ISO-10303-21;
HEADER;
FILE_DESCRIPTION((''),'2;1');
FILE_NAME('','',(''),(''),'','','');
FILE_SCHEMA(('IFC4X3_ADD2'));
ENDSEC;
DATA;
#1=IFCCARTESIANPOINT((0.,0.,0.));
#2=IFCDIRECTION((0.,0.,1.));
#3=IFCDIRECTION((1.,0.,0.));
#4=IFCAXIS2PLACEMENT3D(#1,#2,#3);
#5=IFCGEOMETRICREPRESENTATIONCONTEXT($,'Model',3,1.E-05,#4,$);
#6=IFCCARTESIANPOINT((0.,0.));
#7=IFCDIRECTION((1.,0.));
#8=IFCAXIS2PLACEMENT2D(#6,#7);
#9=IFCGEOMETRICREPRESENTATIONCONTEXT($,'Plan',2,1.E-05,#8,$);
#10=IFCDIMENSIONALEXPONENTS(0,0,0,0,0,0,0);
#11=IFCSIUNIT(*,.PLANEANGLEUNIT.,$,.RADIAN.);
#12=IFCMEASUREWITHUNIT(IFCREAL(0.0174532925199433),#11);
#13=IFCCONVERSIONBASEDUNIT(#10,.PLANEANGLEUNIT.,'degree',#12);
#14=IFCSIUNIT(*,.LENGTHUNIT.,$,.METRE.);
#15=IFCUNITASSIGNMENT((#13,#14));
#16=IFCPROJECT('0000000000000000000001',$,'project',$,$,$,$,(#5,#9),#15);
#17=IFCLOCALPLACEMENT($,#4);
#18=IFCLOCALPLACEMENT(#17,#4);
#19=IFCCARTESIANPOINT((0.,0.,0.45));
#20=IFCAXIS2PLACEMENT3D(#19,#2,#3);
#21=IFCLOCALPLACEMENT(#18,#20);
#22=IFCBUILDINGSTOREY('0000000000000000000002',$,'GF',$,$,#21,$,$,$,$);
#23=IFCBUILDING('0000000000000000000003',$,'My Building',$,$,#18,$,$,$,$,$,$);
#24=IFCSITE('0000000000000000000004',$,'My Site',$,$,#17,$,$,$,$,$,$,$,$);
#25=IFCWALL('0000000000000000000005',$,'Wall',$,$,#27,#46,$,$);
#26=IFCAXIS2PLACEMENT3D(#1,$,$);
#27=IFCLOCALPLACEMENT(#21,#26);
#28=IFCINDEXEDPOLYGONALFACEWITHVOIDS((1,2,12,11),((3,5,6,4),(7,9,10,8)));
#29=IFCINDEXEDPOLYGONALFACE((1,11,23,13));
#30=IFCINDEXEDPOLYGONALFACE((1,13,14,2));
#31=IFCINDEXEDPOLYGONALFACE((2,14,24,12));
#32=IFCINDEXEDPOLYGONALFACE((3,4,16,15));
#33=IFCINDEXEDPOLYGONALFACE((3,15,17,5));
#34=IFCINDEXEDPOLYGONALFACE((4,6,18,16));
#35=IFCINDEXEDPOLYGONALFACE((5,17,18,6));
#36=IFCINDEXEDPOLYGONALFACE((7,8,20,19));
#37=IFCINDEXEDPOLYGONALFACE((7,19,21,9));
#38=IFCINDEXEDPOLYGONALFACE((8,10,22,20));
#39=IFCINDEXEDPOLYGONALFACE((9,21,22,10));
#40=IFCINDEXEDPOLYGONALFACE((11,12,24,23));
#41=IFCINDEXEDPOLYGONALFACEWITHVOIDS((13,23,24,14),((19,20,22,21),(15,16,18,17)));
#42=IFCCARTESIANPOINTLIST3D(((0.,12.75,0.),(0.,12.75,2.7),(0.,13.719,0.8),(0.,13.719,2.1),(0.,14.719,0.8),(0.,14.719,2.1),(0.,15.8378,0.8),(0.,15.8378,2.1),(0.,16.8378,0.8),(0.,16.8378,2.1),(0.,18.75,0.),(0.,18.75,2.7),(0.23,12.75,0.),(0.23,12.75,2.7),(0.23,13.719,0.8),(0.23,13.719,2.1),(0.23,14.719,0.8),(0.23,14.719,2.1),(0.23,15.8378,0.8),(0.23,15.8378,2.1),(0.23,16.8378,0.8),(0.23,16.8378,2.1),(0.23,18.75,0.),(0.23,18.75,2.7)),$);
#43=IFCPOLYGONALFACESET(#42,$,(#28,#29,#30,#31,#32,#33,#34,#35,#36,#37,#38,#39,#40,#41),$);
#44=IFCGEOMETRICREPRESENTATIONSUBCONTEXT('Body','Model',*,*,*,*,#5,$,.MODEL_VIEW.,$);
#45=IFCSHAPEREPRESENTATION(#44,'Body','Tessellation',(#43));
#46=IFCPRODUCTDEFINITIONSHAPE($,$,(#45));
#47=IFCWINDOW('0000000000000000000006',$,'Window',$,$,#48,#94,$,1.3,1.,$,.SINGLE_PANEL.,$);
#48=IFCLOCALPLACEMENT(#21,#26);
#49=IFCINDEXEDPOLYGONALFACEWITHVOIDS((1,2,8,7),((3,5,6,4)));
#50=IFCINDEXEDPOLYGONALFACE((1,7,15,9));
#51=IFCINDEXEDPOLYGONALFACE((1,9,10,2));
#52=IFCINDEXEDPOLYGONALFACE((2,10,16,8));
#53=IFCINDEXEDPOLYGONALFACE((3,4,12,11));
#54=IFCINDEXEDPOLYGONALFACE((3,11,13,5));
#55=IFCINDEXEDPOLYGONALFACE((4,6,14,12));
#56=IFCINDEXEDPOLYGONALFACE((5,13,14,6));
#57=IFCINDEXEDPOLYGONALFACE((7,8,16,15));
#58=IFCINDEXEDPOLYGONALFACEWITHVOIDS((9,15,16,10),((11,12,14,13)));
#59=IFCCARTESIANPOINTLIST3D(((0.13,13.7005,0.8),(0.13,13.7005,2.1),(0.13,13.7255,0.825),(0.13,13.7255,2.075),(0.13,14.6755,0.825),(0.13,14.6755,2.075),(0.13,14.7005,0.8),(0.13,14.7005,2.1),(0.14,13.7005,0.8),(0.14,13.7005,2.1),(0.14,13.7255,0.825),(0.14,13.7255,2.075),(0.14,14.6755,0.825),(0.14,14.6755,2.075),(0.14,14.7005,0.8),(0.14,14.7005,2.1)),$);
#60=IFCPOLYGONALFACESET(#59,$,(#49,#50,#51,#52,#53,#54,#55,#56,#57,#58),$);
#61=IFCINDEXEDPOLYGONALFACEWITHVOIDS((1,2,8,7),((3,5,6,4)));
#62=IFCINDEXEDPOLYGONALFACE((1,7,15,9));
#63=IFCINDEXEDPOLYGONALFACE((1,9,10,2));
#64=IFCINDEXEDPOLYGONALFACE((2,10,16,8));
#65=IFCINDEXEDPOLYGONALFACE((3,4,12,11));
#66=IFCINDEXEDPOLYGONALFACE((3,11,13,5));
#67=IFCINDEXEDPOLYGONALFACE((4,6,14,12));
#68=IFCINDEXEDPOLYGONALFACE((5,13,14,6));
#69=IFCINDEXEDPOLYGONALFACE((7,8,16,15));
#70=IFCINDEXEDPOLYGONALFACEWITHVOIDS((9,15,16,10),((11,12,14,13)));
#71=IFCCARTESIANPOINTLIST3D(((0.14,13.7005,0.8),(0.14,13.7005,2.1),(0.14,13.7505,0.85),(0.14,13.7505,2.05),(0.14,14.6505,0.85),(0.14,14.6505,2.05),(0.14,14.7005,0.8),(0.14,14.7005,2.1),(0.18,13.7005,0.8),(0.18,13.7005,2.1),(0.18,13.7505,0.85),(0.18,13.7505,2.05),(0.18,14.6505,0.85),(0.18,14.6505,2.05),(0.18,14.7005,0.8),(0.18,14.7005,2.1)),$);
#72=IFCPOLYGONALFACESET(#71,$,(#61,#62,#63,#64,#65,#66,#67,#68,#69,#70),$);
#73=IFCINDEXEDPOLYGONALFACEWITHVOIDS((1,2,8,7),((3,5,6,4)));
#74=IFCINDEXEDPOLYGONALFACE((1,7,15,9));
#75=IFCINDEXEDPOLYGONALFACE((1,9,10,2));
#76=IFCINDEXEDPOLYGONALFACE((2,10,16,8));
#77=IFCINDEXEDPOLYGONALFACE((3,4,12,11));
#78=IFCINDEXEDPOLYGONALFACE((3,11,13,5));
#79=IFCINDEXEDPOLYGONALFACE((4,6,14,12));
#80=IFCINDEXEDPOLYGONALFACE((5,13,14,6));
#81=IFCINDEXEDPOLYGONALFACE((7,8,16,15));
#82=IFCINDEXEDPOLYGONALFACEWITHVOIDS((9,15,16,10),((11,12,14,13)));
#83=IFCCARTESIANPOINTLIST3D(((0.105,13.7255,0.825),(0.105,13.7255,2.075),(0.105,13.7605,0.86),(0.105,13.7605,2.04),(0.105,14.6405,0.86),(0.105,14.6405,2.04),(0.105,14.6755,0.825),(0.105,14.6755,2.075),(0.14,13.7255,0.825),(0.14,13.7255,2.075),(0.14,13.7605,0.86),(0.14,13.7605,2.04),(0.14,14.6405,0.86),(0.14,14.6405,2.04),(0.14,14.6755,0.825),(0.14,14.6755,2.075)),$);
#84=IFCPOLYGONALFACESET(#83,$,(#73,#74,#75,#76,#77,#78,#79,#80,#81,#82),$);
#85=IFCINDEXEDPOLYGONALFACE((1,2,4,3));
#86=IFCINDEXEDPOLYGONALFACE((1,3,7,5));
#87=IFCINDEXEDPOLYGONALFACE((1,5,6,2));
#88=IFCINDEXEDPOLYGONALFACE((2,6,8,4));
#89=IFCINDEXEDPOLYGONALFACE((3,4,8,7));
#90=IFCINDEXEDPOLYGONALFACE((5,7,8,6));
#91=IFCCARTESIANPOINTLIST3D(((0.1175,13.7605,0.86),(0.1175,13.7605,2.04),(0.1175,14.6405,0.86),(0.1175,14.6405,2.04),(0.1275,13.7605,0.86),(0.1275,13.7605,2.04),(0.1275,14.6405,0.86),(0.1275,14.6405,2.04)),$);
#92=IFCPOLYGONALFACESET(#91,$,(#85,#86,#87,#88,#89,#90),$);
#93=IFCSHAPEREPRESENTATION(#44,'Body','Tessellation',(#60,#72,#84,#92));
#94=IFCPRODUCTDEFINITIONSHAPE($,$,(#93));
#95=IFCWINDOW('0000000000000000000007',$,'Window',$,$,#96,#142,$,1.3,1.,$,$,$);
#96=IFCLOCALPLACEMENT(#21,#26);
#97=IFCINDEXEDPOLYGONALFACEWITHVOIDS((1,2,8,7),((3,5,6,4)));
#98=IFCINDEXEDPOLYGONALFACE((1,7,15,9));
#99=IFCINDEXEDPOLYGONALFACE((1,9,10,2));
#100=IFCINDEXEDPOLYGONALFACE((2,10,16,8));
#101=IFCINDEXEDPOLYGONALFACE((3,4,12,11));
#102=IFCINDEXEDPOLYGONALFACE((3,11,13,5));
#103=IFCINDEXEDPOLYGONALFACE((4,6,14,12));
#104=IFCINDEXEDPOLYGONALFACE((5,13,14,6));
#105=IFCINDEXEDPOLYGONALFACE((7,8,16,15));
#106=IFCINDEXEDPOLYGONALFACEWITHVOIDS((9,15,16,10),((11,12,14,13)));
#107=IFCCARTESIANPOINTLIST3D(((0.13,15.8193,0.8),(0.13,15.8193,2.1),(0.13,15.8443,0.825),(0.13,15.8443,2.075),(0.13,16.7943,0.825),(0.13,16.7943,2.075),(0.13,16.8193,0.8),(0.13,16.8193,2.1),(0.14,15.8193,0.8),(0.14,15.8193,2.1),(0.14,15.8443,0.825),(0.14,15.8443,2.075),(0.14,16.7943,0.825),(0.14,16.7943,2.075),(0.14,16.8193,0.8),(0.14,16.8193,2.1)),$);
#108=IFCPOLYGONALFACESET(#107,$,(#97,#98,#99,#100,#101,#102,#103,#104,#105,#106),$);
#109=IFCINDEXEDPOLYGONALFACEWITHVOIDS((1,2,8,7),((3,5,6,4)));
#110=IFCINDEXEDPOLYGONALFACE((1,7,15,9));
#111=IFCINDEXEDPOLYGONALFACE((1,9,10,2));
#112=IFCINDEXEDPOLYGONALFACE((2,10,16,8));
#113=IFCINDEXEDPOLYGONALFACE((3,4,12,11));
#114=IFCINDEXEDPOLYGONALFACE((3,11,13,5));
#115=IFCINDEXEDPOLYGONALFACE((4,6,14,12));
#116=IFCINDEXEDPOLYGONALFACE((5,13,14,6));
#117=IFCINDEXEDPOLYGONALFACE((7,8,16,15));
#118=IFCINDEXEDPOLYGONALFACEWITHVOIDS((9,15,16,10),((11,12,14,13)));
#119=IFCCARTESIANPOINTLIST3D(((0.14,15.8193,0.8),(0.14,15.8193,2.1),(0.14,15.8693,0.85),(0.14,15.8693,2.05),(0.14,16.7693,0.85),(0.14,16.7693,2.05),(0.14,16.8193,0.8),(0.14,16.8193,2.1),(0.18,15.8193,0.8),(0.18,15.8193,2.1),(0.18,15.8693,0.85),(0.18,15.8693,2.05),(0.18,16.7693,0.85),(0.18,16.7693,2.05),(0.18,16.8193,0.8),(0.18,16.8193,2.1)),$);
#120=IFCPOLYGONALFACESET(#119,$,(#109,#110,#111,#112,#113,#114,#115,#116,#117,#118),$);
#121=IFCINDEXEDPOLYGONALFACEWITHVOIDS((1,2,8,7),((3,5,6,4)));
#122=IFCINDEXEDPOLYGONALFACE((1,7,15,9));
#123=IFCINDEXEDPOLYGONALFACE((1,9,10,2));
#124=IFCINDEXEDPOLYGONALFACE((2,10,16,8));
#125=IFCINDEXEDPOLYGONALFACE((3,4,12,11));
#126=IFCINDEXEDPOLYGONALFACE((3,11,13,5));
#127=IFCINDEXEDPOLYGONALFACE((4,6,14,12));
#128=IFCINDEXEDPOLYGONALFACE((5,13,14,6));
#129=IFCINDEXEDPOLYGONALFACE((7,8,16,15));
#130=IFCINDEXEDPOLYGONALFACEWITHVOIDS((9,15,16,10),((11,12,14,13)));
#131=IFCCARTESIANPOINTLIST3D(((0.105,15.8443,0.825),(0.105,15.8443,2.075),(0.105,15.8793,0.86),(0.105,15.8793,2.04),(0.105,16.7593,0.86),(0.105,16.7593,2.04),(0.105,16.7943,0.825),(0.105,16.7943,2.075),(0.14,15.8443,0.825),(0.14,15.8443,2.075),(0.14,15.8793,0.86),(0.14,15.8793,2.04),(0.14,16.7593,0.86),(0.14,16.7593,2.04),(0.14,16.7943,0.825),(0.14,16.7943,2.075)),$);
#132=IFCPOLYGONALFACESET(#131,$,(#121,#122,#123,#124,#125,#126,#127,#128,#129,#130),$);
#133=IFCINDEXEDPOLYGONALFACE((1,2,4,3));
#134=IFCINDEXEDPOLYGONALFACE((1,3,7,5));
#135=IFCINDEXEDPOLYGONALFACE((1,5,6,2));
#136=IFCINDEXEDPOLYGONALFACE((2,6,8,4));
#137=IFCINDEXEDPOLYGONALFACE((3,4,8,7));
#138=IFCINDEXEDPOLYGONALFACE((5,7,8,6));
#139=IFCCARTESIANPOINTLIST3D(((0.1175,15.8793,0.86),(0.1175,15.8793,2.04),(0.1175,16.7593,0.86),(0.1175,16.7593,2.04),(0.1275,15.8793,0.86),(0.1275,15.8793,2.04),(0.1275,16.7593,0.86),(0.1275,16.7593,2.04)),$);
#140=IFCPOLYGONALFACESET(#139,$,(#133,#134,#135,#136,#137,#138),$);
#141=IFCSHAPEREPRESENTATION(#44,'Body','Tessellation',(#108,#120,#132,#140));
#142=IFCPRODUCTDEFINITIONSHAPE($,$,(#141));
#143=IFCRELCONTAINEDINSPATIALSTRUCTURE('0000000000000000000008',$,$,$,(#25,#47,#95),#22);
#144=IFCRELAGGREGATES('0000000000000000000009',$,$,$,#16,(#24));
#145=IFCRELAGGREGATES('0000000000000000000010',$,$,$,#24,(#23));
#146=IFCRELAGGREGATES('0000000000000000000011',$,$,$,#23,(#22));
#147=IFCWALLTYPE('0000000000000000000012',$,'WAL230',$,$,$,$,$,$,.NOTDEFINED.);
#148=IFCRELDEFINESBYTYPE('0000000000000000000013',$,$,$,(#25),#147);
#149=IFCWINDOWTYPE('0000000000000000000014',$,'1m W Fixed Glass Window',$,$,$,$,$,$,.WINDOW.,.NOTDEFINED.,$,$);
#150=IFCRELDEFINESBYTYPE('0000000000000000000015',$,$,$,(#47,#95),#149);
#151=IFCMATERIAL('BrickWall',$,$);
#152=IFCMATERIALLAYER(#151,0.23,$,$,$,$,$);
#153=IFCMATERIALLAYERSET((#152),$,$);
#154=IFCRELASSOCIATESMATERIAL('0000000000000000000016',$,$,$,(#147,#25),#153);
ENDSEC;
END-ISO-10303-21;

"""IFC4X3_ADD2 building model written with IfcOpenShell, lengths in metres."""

from ifc_helpers import new_model, entity, si_unit, converted_unit, frame, origin_with_axes, origin_2d_with_axis, place, context, subcontext, project, spatial, line, indexed_curve, outline, extrude, shape, source, transform, mapped, material, layer, layer_set, layer_usage, type_object, type_shapes, element, fill, save


model = new_model("IFC4X3_ADD2")

# Units and contexts
model_context = context("Model", 3, precision=1e-05, world=origin_with_axes())
plan_context = context("Plan", 2, precision=1e-05, world=origin_2d_with_axis())
body_context_1 = subcontext(model_context, "Body", "Model", "MODEL_VIEW")
body_context_2 = subcontext(plan_context, "Body", "Plan", "PLAN_VIEW")
ifc_project = project(units=[converted_unit("PLANEANGLEUNIT", "degree", entity("IfcReal", 0.0174532925199433), si_unit("PLANEANGLEUNIT", "RADIAN"), dimensions=[0, 0, 0, 0, 0, 0, 0]), si_unit("LENGTHUNIT", "METRE")], contexts=[model_context, plan_context])

# Site, building, storey
site_placement = place(None, origin_with_axes())
site = spatial("IfcSite", under=ifc_project, at=site_placement, Name="My Site")
building_placement = place(site_placement, origin_with_axes())
building = spatial("IfcBuilding", under=site, at=building_placement, Name="My Building")
storey_placement = place(building_placement, frame((0.0, 0.0, 0.45), z_axis=(0.0, 0.0, 1.0), x_axis=(1.0, 0.0, 0.0)))
storey = spatial("IfcBuildingStorey", under=building, at=storey_placement, Name="GF")

# Shared definitions
ifc_material_1 = material(Name="BrickWall")
ifc_layer_1 = layer(ifc_material_1, 0.23)
ifc_layer_set_1 = layer_set([ifc_layer_1])
wall_type_1 = type_object("IfcWallType", Name="WAL230", PredefinedType="NOTDEFINED", material=ifc_layer_set_1)

# Wall, openings, windows
ifc_layer_usage_1 = layer_usage(ifc_layer_set_1, "AXIS2", "POSITIVE", 0.0)
wall_1_placement = place(storey_placement, frame((0.23, 12.75, 0.0), z_axis=(0.0, 0.0, 1.0), x_axis=(0.0, 1.0, 0.0)))
wall_1 = element("IfcWall", 1, at=wall_1_placement, inside=storey, type_object=wall_type_1, material=ifc_layer_usage_1, Name="Wall", context=body_context_1, shape_type="SweptSolid", body=[
    extrude(outline(indexed_curve([(0.0, 0.0), (0.0, 0.23), (6.0, 0.23), (6.0, 0.0), (0.0, 0.0)], self_intersect=False)), origin_with_axes(), (0.0, 0.0, 1.0), 2.7),
])
shared_shape_1 = source(origin_with_axes(), body_context_1, "Body", "SweptSolid", [
    extrude(outline(indexed_curve([(0.0, 0.0), (1.0, 0.0), (1.0, 1.3), (0.0, 1.3)], segments=[line(1, 2, 3, 4, 1)])), frame((0.0, -0.6, 0.0), z_axis=(0.0, -1.0, 0.0), x_axis=(1.0, 0.0, 0.0)), (0.0, 0.0, -1.0), 1.2),
])
opening_1_placement = place(wall_1_placement, frame((0.969, 0.0, 0.8), z_axis=(0.0, 0.0, 1.0), x_axis=(1.0, 0.0, 0.0)))
opening_1 = element("IfcOpeningElement", 2, at=opening_1_placement, cuts=wall_1, PredefinedType="OPENING", context=body_context_1, shape_type="MappedRepresentation", body=[
    mapped(shared_shape_1, transform((0.0, 0.0, 0.0), x_axis=(1.0, 0.0, 0.0), y_axis=(0.0, 1.0, 0.0), z_axis=(0.0, 0.0, 1.0), scale=1.0)),
])
opening_2_placement = place(wall_1_placement, frame((3.0878, 0.0, 0.8), z_axis=(0.0, 0.0, 1.0), x_axis=(1.0, 0.0, 0.0)))
opening_2 = element("IfcOpeningElement", 3, at=opening_2_placement, cuts=wall_1, PredefinedType="OPENING", context=body_context_1, shape_type="MappedRepresentation", body=[
    mapped(shared_shape_1, transform((0.0, 0.0, 0.0), x_axis=(1.0, 0.0, 0.0), y_axis=(0.0, 1.0, 0.0), z_axis=(0.0, 0.0, 1.0), scale=1.0)),
])
window_type = type_object("IfcWindowType", Name="1m W Fixed Glass Window", PartitioningType="NOTDEFINED", PredefinedType="WINDOW")
shared_shape_2 = source(origin_with_axes(), body_context_1, "Body", "SweptSolid", [
    extrude(outline(indexed_curve([(0.0, 0.0), (1.0, 0.0), (1.0, 1.3), (0.0, 1.3)], segments=[line(1, 2, 3, 4, 1)]), holes=[indexed_curve([(0.025, 0.025), (0.975, 0.025), (0.975, 1.275), (0.025, 1.275)], segments=[line(1, 2, 3, 4, 1)])]), frame((0.0, 0.09, 0.0), z_axis=(0.0, -1.0, 0.0), x_axis=(1.0, 0.0, 0.0)), (0.0, 0.0, -1.0), 0.01),
    extrude(outline(indexed_curve([(0.0, 0.0), (1.0, 0.0), (1.0, 1.3), (0.0, 1.3)], segments=[line(1, 2, 3, 4, 1)]), holes=[indexed_curve([(0.05, 0.05), (0.95, 0.05), (0.95, 1.25), (0.05, 1.25)], segments=[line(1, 2, 3, 4, 1)])]), frame((0.0, 0.05, 0.0), z_axis=(0.0, -1.0, 0.0), x_axis=(1.0, 0.0, 0.0)), (0.0, 0.0, -1.0), 0.04),
    extrude(outline(indexed_curve([(0.0, 0.0), (0.95, 0.0), (0.95, 1.25), (0.0, 1.25)], segments=[line(1, 2, 3, 4, 1)]), holes=[indexed_curve([(0.035, 0.035), (0.915, 0.035), (0.915, 1.215), (0.035, 1.215)], segments=[line(1, 2, 3, 4, 1)])]), frame((0.025, 0.09, 0.025), z_axis=(0.0, -1.0, 0.0), x_axis=(1.0, 0.0, 0.0)), (0.0, 0.0, -1.0), 0.035),
    extrude(outline(indexed_curve([(0.035, 0.035), (0.915, 0.035), (0.915, 1.215), (0.035, 1.215)], segments=[line(1, 2, 3, 4, 1)])), frame((0.025, 0.1025, 0.025), z_axis=(0.0, -1.0, 0.0), x_axis=(1.0, 0.0, 0.0)), (0.0, 0.0, -1.0), 0.01),
])
shared_shape_3 = source(origin_with_axes(), body_context_2, "Body", "Curve2D", [
    entity("IfcIndexedPolyCurve", entity("IfcCartesianPointList2D", [[0.05, 0.05], [0.95, 0.05]])),
    entity("IfcIndexedPolyCurve", entity("IfcCartesianPointList2D", [[0.0, 0.1], [0.025, 0.1], [0.025, 0.09], [0.05, 0.09], [0.05, 0.05], [0.0, 0.05]]), [entity("IfcLineIndex", [1, 2, 3, 4, 5, 6, 1])]),
    entity("IfcIndexedPolyCurve", entity("IfcCartesianPointList2D", [[1.0, 0.1], [0.975, 0.1], [0.975, 0.09], [0.95, 0.09], [0.95, 0.05], [1.0, 0.05]]), [entity("IfcLineIndex", [1, 2, 3, 4, 5, 6, 1])]),
    entity("IfcIndexedPolyCurve", entity("IfcCartesianPointList2D", [[0.025, 0.09], [0.06, 0.09], [0.06, 0.125], [0.025, 0.125]]), [entity("IfcLineIndex", [1, 2, 3, 4, 1])]),
    entity("IfcIndexedPolyCurve", entity("IfcCartesianPointList2D", [[0.975, 0.09], [0.94, 0.09], [0.94, 0.125], [0.975, 0.125]]), [entity("IfcLineIndex", [1, 2, 3, 4, 1])]),
    entity("IfcIndexedPolyCurve", entity("IfcCartesianPointList2D", [[0.06, 0.09], [0.94, 0.09]])),
    entity("IfcIndexedPolyCurve", entity("IfcCartesianPointList2D", [[0.06, 0.125], [0.94, 0.125]])),
    entity("IfcIndexedPolyCurve", entity("IfcCartesianPointList2D", [[0.06, 0.1075], [0.94, 0.1075]])),
])
type_shapes(window_type, [shared_shape_2, shared_shape_3])
window_1_placement = place(opening_1_placement, frame((-0.0184, 0.0, 0.0), z_axis=(0.0, 0.0, 1.0), x_axis=(1.0, 0.0, 0.0)))
window_1 = element("IfcWindow", 4, at=window_1_placement, inside=storey, type_object=window_type, Name="Window", OverallHeight=1.3, OverallWidth=1.0, PartitioningType="SINGLE_PANEL", shapes=[
    shape(body_context_1, "Body", "MappedRepresentation", [mapped(shared_shape_2, transform((0.0, 0.0, 0.0), x_axis=(1.0, 0.0, 0.0), y_axis=(0.0, 1.0, 0.0), z_axis=(0.0, 0.0, 1.0), scale=1.0))]),
    shape(body_context_2, "Body", "MappedRepresentation", [mapped(shared_shape_3, transform((0.0, 0.0, 0.0), x_axis=(1.0, 0.0, 0.0), y_axis=(0.0, 1.0, 0.0), z_axis=(0.0, 0.0, 1.0), scale=1.0))]),
])
fill(opening_1, window_1)
window_2_placement = place(opening_2_placement, frame((-0.0184, 0.0, 0.0), z_axis=(0.0, 0.0, 1.0), x_axis=(1.0, 0.0, 0.0)))
window_2 = element("IfcWindow", 5, at=window_2_placement, inside=storey, type_object=window_type, Name="Window", OverallHeight=1.3, OverallWidth=1.0, shapes=[
    shape(body_context_1, "Body", "MappedRepresentation", [mapped(shared_shape_2, transform((0.0, 0.0, 0.0), x_axis=(1.0, 0.0, 0.0), y_axis=(0.0, 1.0, 0.0), z_axis=(0.0, 0.0, 1.0), scale=1.0))]),
    shape(body_context_2, "Body", "MappedRepresentation", [mapped(shared_shape_3, transform((0.0, 0.0, 0.0), x_axis=(1.0, 0.0, 0.0), y_axis=(0.0, 1.0, 0.0), z_axis=(0.0, 0.0, 1.0), scale=1.0))]),
])
fill(opening_2, window_2)

save(model, "model.ifc")
